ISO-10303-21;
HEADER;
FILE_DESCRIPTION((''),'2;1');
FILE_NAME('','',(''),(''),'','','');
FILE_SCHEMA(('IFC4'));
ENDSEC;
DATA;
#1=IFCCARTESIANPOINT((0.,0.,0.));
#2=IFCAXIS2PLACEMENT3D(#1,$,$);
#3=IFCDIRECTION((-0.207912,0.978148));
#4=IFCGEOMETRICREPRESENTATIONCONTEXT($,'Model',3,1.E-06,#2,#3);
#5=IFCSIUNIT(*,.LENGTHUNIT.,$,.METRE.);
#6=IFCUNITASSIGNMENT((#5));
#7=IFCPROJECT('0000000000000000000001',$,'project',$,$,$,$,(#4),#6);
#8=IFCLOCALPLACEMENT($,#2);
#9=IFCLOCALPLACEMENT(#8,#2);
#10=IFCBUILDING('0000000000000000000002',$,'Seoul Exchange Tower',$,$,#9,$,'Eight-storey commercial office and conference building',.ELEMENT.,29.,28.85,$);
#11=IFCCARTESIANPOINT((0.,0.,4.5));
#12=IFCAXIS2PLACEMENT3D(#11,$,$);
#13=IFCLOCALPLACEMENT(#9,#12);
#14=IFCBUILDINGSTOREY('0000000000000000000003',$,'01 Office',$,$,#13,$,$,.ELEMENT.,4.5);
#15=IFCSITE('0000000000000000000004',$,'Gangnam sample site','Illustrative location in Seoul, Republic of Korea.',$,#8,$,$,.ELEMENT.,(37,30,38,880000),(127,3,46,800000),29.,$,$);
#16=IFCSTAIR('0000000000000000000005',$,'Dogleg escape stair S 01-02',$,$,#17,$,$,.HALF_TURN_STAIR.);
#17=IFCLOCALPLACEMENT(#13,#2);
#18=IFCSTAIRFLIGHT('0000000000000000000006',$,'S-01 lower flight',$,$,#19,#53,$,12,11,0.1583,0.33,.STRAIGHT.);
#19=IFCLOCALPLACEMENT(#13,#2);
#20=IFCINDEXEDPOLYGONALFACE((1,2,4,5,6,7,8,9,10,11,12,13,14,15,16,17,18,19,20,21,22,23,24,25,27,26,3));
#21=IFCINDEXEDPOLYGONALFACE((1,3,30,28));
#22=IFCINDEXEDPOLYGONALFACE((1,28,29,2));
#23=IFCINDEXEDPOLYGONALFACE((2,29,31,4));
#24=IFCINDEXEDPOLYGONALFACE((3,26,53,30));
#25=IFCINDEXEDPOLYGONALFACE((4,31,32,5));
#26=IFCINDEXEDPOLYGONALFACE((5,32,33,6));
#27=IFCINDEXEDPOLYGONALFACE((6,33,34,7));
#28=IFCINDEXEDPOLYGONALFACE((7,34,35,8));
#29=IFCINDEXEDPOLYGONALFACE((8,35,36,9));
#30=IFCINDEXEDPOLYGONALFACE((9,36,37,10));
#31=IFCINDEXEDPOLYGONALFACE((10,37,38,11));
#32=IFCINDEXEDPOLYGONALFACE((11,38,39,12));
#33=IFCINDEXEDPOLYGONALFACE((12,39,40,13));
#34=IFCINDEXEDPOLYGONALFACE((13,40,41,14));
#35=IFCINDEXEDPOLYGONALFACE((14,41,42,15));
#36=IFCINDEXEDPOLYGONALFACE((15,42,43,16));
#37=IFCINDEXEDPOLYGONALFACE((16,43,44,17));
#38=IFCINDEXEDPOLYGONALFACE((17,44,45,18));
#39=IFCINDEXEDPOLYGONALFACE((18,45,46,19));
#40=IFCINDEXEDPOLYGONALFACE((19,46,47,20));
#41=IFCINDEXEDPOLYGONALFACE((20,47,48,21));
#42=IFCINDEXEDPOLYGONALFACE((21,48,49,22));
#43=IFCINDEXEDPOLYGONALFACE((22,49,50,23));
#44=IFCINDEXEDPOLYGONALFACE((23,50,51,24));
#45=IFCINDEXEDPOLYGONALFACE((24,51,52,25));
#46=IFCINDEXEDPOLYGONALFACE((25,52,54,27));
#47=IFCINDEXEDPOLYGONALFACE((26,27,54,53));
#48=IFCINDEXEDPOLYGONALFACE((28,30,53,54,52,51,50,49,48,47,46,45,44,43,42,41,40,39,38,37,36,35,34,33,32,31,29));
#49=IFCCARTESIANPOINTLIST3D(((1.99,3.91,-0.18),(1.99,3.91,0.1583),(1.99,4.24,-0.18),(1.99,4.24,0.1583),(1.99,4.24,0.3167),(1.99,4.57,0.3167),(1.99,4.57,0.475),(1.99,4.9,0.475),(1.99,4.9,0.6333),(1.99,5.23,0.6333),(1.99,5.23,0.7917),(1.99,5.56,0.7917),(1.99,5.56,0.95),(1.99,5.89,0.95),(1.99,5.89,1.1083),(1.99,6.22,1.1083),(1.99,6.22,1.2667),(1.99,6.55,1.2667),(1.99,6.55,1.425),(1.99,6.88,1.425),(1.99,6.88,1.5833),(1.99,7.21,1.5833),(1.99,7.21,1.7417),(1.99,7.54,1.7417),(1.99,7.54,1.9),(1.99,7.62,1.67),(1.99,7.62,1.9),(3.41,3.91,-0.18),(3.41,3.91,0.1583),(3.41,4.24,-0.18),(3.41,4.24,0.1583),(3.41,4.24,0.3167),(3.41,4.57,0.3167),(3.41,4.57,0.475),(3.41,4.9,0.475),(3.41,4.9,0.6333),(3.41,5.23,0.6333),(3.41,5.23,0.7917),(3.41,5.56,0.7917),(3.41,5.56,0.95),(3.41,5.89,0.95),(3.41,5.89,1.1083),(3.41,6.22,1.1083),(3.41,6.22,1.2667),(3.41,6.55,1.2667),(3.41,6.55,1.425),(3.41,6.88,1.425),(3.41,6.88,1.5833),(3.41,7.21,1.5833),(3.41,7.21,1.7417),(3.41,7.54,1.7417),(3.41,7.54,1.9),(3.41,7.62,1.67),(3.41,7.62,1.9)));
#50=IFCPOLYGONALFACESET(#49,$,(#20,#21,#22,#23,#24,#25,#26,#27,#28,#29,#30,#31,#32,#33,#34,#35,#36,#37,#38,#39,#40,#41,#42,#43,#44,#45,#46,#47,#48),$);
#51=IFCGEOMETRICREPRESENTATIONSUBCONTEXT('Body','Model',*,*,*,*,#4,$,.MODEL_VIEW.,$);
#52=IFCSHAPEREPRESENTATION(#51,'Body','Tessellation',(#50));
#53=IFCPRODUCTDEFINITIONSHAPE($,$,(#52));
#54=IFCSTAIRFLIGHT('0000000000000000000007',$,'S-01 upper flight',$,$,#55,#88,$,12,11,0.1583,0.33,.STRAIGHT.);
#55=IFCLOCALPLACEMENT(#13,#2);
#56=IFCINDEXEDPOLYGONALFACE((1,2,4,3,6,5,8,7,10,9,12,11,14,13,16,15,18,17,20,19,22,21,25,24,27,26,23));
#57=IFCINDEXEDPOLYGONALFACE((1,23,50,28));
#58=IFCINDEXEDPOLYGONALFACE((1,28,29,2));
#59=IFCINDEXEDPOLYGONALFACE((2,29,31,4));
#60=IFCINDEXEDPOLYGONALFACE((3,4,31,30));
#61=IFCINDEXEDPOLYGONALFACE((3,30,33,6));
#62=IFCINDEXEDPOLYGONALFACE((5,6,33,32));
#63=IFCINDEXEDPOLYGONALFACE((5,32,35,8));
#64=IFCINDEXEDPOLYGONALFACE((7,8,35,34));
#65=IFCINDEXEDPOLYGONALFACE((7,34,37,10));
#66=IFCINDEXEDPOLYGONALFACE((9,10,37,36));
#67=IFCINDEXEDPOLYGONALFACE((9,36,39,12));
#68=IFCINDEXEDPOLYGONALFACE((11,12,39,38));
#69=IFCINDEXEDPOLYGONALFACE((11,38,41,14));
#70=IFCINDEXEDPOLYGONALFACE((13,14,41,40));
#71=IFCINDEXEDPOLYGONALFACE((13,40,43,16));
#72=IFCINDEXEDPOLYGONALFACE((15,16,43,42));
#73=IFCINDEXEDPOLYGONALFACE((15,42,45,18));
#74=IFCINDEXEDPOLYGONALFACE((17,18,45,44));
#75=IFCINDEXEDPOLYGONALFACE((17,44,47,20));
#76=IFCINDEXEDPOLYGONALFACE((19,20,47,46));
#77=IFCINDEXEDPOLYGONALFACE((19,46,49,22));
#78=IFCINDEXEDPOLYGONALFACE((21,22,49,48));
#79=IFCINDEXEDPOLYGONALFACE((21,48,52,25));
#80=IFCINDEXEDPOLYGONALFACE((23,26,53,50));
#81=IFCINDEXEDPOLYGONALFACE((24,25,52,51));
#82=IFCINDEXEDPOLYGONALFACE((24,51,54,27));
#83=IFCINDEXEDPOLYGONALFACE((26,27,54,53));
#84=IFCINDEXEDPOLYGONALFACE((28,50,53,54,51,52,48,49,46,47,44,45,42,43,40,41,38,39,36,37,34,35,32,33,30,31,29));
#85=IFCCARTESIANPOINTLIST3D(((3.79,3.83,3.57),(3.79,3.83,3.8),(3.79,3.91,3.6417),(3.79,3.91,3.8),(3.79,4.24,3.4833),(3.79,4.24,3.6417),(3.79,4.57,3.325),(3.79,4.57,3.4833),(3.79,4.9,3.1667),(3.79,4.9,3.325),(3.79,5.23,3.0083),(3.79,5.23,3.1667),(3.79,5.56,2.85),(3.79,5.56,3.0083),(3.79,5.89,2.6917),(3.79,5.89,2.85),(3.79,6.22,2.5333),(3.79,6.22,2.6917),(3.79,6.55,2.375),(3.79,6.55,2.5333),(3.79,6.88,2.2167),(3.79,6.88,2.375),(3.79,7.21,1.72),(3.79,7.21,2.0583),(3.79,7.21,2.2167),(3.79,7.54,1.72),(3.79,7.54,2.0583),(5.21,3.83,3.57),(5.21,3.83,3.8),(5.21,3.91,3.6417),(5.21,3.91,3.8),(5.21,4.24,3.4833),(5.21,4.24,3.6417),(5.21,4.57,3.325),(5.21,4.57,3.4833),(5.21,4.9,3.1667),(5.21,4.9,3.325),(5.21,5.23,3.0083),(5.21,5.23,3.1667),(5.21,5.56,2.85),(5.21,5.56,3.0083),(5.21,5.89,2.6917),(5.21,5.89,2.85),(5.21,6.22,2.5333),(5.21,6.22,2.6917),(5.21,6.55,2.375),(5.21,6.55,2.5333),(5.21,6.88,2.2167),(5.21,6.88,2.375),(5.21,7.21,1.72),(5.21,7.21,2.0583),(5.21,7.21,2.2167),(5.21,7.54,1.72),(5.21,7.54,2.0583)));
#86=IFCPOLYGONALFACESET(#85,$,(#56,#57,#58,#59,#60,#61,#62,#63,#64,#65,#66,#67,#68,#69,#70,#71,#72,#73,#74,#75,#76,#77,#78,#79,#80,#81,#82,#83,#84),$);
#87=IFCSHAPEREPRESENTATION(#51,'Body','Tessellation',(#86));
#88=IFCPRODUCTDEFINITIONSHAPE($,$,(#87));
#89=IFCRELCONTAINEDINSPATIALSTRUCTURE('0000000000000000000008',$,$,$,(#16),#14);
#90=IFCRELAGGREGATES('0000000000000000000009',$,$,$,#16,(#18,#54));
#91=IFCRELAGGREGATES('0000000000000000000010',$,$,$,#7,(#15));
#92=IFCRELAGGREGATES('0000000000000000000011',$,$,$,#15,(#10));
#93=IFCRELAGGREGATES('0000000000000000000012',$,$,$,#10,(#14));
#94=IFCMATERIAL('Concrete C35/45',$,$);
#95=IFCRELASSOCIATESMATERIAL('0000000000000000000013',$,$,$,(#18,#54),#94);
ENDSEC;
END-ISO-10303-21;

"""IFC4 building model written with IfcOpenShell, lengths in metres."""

from ifc_helpers import new_model, si_unit, direction, frame, origin, place, context, subcontext, project, spatial, polyline, outline, extrude, material, element, aggregate, save


model = new_model("IFC4")

# Units and contexts
model_context = context("Model", 3, precision=1e-06, world=origin(), true_north=direction((-0.207912, 0.978148)))
body_context = subcontext(model_context, "Body", "Model", "MODEL_VIEW")
ifc_project = project(units=[si_unit("LENGTHUNIT", "METRE")], contexts=[model_context])

# Site, building, storey
site_placement = place(None, origin())
site = spatial("IfcSite", under=ifc_project, at=site_placement, Name="Gangnam sample site", Description="Illustrative location in Seoul, Republic of Korea.", CompositionType="ELEMENT", RefLatitude=(37, 30, 38, 880000), RefLongitude=(127, 3, 46, 800000), RefElevation=29.0)
building_placement = place(site_placement, origin())
building = spatial("IfcBuilding", under=site, at=building_placement, Name="Seoul Exchange Tower", LongName="Eight-storey commercial office and conference building", CompositionType="ELEMENT", ElevationOfRefHeight=29.0, ElevationOfTerrain=28.85)
storey_placement = place(building_placement, frame((0.0, 0.0, 4.5)))
storey = spatial("IfcBuildingStorey", under=building, at=storey_placement, Name="01 Office", CompositionType="ELEMENT", Elevation=4.5)

# Shared definitions
ifc_material_1 = material(Name="Concrete C35/45")
placement_1 = place(storey_placement, origin())

# Stair
placement_2 = place(placement_1, origin())
stair_1 = element("IfcStair", 1, at=placement_1, inside=storey, Name="Dogleg escape stair S 01-02", PredefinedType="HALF_TURN_STAIR")

# Stair flights
stair_flight_1 = element("IfcStairFlight", 2, at=placement_2, material=ifc_material_1, Name="S-01 lower flight", NumberOfRisers=12, NumberOfTreads=11, PredefinedType="STRAIGHT", RiserHeight=0.1583, TreadLength=0.33, context=body_context, shape_type="SweptSolid", body=[
    extrude(outline(polyline([(0.0, -0.18), (0.0, 0.1583), (0.33, 0.1583), (0.33, 0.3167), (0.66, 0.3167), (0.66, 0.475), (0.99, 0.475), (0.99, 0.6333), (1.32, 0.6333), (1.32, 0.7917), (1.65, 0.7917), (1.65, 0.95), (1.98, 0.95), (1.98, 1.1083), (2.31, 1.1083), (2.31, 1.2667), (2.64, 1.2667), (2.64, 1.425), (2.97, 1.425), (2.97, 1.5833), (3.3, 1.5833), (3.3, 1.7417), (3.63, 1.7417), (3.63, 1.9), (3.71, 1.9), (3.71, 1.67), (0.33, -0.18), (0.0, -0.18)])), frame((1.99, 3.91, 0.0), z_axis=(1.0, 0.0, 0.0), x_axis=(0.0, 1.0, 0.0)), (0.0, 0.0, 1.0), 1.42),
])
stair_flight_2 = element("IfcStairFlight", 3, at=placement_2, material=ifc_material_1, Name="S-01 upper flight", NumberOfRisers=12, NumberOfTreads=11, PredefinedType="STRAIGHT", RiserHeight=0.1583, TreadLength=0.33, context=body_context, shape_type="SweptSolid", body=[
    extrude(outline(polyline([(0.0, -0.18), (0.0, 0.1583), (0.33, 0.1583), (0.33, 0.3167), (0.66, 0.3167), (0.66, 0.475), (0.99, 0.475), (0.99, 0.6333), (1.32, 0.6333), (1.32, 0.7917), (1.65, 0.7917), (1.65, 0.95), (1.98, 0.95), (1.98, 1.1083), (2.31, 1.1083), (2.31, 1.2667), (2.64, 1.2667), (2.64, 1.425), (2.97, 1.425), (2.97, 1.5833), (3.3, 1.5833), (3.3, 1.7417), (3.63, 1.7417), (3.63, 1.9), (3.71, 1.9), (3.71, 1.67), (0.33, -0.18), (0.0, -0.18)])), frame((5.21, 7.54, 1.9), z_axis=(-1.0, 0.0, 0.0), x_axis=(0.0, -1.0, 0.0)), (0.0, 0.0, 1.0), 1.42),
])

aggregate(stair_1, [stair_flight_1, stair_flight_2])

save(model, "model.ifc")
